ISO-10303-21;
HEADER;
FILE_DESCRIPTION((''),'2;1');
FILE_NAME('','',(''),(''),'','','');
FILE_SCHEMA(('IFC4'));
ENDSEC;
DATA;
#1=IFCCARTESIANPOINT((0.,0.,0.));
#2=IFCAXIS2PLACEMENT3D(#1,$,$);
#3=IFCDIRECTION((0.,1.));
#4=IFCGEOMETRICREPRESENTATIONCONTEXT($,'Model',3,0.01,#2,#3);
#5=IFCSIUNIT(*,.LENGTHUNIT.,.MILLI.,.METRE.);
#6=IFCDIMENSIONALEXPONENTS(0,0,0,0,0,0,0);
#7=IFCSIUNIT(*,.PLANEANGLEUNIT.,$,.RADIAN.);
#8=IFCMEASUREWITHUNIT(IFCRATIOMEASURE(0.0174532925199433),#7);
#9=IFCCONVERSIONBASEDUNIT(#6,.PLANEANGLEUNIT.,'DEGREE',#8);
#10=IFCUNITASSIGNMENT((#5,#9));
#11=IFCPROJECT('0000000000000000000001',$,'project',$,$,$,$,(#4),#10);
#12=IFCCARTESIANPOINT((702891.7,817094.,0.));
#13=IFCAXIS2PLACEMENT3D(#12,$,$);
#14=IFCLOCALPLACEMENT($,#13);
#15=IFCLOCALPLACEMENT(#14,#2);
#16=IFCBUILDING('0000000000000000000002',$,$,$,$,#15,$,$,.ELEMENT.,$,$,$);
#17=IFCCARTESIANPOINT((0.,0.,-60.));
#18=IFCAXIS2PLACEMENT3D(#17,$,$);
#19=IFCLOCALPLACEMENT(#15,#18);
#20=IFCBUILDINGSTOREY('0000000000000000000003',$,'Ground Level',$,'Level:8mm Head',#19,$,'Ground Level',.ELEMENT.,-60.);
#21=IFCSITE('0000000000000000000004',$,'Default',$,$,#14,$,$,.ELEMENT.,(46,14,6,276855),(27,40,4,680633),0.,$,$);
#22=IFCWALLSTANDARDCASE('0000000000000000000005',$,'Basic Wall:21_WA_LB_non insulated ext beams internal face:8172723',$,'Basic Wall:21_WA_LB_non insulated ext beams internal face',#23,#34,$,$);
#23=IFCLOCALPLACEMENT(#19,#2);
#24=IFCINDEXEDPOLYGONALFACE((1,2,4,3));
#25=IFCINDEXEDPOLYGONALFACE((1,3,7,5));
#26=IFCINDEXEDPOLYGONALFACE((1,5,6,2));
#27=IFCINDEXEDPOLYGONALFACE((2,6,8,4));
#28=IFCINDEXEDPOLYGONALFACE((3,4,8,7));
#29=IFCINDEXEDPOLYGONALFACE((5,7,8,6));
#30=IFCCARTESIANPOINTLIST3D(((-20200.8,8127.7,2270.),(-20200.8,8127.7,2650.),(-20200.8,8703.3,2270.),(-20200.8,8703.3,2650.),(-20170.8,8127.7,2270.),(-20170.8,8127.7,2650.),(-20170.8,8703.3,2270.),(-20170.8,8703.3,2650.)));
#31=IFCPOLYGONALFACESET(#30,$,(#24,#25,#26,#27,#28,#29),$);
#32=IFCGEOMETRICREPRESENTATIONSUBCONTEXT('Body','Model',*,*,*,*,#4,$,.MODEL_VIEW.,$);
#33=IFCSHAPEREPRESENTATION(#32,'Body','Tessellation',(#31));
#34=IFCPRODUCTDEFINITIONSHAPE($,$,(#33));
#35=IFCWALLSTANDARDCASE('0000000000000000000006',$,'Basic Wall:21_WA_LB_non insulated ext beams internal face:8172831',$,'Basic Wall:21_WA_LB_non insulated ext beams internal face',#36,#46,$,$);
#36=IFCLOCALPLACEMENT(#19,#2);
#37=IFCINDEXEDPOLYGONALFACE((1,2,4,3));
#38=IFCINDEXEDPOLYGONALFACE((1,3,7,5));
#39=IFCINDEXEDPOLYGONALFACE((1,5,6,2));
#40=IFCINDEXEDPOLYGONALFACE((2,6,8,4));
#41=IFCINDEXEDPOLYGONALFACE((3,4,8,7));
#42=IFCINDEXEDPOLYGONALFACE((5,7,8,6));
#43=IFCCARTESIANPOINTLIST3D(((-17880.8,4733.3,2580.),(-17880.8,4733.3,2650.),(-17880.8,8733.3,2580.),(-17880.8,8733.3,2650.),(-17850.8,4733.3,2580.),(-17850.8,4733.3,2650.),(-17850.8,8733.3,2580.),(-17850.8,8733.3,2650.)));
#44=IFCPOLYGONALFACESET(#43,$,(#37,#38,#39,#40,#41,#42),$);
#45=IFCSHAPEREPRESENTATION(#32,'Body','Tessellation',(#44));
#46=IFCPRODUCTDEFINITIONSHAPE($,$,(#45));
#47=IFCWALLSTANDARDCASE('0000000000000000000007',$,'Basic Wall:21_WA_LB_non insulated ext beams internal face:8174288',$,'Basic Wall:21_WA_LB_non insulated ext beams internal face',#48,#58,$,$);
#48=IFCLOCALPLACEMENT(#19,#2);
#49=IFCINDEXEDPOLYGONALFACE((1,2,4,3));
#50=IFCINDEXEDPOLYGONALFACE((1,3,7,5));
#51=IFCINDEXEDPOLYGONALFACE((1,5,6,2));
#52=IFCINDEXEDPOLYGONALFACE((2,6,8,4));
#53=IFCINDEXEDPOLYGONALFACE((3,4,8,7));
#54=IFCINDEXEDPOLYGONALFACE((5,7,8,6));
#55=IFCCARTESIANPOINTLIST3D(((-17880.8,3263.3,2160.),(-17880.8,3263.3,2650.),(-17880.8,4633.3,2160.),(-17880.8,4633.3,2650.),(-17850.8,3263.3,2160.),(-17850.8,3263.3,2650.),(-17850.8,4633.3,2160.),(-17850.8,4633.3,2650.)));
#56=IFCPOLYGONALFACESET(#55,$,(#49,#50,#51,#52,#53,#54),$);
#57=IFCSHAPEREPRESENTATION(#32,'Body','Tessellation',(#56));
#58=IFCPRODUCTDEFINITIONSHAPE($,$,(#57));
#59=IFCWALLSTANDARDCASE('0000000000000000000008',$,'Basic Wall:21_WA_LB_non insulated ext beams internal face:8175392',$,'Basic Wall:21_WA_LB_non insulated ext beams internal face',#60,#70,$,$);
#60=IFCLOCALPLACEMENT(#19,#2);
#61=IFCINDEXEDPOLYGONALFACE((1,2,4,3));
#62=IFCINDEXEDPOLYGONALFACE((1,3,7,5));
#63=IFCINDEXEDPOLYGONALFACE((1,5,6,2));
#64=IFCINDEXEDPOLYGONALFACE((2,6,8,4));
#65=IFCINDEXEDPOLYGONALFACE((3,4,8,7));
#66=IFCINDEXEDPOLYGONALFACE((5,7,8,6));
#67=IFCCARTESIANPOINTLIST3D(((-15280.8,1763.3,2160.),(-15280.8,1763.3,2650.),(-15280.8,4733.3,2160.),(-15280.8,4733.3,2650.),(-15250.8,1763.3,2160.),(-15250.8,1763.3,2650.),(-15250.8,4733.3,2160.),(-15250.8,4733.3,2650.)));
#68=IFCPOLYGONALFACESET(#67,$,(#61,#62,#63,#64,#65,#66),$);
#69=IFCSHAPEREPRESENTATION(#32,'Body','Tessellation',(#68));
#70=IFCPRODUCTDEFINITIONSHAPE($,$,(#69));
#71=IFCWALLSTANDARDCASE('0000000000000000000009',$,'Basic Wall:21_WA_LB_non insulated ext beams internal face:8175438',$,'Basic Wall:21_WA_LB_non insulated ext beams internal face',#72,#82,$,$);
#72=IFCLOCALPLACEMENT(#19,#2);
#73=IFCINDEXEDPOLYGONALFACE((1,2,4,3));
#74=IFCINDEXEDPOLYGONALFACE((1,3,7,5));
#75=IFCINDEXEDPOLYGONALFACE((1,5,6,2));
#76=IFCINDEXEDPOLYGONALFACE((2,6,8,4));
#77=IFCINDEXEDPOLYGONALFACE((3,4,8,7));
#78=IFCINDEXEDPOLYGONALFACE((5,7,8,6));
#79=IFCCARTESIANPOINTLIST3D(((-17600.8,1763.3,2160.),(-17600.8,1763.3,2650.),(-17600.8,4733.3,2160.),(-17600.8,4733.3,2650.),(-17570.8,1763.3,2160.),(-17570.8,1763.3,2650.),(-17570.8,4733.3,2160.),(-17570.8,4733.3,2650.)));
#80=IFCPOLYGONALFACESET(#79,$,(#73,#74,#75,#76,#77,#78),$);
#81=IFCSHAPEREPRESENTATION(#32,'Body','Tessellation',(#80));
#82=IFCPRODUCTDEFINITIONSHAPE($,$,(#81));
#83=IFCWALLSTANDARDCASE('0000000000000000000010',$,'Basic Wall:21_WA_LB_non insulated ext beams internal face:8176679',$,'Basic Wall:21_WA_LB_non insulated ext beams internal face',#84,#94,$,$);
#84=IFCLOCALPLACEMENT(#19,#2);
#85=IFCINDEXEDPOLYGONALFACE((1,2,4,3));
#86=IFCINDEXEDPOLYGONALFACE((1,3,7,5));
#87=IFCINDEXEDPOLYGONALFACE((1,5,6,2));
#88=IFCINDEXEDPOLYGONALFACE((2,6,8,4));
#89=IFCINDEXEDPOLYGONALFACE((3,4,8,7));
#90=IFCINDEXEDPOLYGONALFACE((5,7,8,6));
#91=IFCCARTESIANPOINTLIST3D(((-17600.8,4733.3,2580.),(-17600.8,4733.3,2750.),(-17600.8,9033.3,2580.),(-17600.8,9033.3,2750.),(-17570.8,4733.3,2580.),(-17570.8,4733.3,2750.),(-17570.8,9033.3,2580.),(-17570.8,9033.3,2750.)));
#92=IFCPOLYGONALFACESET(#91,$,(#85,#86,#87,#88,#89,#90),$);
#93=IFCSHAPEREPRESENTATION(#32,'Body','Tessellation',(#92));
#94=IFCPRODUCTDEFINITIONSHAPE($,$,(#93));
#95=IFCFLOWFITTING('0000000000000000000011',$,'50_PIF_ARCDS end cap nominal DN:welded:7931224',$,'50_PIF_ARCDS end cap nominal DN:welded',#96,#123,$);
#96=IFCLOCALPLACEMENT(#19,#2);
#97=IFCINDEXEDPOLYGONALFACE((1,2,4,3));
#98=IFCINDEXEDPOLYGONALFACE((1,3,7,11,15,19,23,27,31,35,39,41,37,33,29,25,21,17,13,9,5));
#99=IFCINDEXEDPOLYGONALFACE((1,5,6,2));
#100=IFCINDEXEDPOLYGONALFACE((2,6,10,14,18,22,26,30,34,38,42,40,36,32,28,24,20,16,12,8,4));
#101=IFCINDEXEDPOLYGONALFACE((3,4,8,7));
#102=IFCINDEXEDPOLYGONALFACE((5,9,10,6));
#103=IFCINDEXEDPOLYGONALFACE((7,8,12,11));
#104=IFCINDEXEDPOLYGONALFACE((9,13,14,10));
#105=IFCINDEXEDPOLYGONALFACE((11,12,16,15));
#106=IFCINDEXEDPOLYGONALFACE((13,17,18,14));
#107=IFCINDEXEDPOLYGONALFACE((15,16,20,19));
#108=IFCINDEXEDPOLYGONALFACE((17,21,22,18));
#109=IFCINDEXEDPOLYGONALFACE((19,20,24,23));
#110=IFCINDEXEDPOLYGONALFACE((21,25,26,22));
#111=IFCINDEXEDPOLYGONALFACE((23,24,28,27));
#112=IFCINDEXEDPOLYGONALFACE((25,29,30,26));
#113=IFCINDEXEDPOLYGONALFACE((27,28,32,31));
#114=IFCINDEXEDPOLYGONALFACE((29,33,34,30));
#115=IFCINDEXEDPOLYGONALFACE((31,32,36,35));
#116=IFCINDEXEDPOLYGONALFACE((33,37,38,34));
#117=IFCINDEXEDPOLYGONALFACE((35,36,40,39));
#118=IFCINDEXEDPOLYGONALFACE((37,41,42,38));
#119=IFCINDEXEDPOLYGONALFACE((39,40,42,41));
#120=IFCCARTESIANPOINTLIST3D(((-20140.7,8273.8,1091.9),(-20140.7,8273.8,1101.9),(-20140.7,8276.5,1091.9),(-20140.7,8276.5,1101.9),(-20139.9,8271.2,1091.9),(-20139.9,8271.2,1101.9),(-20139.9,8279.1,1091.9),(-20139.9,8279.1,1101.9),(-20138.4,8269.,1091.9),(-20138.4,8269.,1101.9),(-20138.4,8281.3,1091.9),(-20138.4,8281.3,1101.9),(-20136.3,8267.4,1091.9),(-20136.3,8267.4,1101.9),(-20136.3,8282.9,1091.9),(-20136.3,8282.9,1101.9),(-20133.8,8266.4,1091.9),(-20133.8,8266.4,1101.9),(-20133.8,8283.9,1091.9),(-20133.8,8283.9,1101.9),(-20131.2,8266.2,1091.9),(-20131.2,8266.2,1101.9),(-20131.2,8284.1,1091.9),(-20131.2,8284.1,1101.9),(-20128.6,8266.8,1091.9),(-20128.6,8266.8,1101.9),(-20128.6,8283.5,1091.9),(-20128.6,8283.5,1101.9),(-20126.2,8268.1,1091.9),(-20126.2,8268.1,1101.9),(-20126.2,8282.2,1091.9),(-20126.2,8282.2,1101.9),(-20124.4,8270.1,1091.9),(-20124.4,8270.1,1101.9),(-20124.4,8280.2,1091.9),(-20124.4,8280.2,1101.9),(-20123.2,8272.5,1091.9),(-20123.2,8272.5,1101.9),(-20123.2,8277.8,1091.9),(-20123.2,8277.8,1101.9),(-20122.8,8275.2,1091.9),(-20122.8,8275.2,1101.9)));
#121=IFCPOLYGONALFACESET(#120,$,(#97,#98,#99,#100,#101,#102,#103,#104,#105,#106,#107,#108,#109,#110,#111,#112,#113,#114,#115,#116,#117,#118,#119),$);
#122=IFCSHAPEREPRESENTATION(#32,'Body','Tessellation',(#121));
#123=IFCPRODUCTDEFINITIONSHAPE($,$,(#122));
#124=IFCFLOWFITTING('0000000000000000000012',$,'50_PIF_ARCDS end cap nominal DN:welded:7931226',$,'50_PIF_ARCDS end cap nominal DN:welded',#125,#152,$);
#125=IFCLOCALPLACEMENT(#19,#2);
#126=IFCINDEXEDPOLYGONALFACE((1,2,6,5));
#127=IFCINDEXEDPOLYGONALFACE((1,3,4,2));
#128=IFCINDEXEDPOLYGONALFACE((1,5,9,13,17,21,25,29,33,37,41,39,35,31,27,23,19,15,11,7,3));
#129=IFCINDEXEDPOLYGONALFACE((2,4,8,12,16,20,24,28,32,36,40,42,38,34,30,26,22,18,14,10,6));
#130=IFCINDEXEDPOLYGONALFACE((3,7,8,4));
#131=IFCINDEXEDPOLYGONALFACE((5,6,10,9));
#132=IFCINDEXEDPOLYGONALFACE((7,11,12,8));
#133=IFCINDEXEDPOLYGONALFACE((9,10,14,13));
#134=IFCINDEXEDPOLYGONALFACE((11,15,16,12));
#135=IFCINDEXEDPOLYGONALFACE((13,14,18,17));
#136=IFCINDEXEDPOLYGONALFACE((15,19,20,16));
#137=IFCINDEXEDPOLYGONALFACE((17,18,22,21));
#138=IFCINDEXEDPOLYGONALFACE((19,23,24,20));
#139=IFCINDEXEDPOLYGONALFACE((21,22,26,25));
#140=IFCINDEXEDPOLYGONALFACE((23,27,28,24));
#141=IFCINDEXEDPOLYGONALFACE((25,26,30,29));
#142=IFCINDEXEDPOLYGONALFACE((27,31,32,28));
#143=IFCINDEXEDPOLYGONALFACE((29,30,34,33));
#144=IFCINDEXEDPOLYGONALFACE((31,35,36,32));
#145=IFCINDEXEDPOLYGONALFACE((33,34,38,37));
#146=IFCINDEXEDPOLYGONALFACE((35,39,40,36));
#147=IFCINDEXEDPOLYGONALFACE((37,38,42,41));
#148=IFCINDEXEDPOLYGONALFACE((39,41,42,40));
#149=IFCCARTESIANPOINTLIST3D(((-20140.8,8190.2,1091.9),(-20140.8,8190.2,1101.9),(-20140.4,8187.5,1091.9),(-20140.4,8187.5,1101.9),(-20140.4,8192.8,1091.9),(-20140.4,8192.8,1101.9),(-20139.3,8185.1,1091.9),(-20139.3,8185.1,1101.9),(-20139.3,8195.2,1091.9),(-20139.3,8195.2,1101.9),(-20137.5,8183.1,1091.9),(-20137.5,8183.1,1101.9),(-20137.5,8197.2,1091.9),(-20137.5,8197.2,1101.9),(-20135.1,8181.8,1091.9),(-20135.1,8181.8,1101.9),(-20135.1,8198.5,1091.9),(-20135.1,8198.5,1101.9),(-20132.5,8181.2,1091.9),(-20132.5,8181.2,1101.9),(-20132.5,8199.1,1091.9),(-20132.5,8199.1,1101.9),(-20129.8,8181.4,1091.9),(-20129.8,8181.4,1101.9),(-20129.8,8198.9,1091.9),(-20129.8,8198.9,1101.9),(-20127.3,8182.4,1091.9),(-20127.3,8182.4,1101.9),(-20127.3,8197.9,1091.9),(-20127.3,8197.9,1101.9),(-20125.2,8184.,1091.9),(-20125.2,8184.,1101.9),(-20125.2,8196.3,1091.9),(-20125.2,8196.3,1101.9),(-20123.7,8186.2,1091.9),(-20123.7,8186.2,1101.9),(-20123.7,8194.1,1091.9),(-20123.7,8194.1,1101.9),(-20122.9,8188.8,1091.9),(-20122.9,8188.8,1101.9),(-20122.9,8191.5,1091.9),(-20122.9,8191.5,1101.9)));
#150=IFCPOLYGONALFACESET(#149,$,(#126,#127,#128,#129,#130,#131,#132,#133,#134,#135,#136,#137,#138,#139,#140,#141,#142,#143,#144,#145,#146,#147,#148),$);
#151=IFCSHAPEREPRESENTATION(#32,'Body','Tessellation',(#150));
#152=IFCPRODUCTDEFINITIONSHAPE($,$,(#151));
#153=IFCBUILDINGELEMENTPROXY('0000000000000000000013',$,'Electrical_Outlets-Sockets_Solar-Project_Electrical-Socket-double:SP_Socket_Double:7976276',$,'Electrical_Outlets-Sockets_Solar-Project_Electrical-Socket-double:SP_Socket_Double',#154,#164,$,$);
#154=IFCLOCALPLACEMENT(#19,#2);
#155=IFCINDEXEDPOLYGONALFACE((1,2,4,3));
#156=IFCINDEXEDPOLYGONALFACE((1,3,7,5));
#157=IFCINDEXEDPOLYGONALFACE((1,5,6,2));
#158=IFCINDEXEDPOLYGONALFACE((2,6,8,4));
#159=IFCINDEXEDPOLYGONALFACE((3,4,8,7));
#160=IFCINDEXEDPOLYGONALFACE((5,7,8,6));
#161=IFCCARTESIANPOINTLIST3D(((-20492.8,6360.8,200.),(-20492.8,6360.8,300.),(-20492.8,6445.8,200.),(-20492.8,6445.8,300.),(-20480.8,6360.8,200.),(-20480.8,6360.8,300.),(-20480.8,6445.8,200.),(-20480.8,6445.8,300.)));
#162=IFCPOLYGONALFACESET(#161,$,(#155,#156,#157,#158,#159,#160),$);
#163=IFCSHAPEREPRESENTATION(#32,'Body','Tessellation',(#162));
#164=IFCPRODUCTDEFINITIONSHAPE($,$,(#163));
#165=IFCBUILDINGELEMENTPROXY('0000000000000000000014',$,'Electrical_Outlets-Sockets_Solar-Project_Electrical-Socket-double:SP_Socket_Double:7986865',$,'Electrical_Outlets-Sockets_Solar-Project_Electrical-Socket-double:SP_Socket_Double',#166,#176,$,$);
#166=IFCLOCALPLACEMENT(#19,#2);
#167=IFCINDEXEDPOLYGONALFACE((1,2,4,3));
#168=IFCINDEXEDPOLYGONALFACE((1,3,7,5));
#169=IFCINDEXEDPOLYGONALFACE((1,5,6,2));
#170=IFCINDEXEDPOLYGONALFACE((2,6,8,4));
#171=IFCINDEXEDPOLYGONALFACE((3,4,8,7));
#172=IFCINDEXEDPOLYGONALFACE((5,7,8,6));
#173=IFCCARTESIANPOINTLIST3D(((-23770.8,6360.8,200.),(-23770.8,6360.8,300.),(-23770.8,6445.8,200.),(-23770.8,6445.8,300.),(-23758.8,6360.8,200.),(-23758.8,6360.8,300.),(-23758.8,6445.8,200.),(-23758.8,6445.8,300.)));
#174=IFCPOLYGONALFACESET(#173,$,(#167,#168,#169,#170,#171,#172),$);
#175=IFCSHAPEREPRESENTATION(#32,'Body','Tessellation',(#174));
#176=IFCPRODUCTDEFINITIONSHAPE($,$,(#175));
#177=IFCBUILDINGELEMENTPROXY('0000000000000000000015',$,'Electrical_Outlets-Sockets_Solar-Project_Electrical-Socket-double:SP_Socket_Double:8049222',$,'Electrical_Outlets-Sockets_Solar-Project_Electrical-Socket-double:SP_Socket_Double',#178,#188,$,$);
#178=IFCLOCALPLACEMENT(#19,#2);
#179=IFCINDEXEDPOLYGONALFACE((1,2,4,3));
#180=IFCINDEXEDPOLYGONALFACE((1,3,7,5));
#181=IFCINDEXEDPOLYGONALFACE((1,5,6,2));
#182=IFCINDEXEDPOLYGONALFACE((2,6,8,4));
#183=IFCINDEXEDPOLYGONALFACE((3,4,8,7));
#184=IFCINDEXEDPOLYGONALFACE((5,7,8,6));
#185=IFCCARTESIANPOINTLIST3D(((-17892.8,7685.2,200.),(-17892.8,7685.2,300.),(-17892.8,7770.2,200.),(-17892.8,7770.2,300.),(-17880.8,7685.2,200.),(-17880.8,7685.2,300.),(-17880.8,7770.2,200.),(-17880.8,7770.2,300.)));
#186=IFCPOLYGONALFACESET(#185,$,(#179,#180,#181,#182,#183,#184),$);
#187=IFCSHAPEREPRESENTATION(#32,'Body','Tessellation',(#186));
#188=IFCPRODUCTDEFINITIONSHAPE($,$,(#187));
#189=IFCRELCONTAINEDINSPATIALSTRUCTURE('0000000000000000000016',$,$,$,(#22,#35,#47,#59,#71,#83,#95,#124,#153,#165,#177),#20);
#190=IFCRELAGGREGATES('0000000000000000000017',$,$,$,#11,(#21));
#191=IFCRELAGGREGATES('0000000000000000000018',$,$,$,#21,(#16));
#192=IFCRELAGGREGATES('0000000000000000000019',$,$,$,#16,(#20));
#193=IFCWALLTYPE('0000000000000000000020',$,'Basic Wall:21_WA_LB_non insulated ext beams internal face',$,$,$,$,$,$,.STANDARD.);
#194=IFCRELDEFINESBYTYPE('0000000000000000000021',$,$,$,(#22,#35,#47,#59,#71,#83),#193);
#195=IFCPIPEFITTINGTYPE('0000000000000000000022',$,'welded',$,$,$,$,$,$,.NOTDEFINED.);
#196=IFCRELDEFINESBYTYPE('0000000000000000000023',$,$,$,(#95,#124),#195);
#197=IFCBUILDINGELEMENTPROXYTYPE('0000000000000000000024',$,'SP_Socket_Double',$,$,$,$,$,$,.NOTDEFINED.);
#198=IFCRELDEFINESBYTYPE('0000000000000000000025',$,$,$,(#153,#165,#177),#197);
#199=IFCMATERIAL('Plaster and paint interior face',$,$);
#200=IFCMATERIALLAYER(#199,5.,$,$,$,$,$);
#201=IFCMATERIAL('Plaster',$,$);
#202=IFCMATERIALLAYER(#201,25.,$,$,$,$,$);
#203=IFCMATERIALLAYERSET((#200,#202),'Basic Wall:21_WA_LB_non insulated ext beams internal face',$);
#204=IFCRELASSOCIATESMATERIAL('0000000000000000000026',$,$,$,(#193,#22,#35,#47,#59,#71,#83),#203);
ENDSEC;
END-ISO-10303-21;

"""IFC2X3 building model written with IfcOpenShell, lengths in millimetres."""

from ifc_helpers import new_model, entity, si_unit, converted_unit, direction, frame, frame_2d, origin, origin_2d_with_axis, place, context, subcontext, project, spatial, rectangle, circle, extrude, source, transform, mapped, material, layer, layer_set, layer_usage, type_object, type_shapes, element, save


model = new_model("IFC2X3")

# Units and contexts
model_context = context("Model", 3, precision=0.01, world=origin(), true_north=direction((0.0, 1.0)))
body_context = subcontext(model_context, "Body", "Model", "MODEL_VIEW")
ifc_project = project(units=[si_unit("LENGTHUNIT", "METRE", prefix="MILLI"), converted_unit("PLANEANGLEUNIT", "DEGREE", entity("IfcRatioMeasure", 0.0174532925199433), si_unit("PLANEANGLEUNIT", "RADIAN"), dimensions=[0, 0, 0, 0, 0, 0, 0])], contexts=[model_context])

# Site, building, storey
site_placement = place(None, frame((702891.7, 817094.0, 0.0)))
site = spatial("IfcSite", under=ifc_project, at=site_placement, Name="Default", CompositionType="ELEMENT", RefLatitude=(46, 14, 6, 276855), RefLongitude=(27, 40, 4, 680633), RefElevation=0.0)
building_placement = place(site_placement, origin())
building = spatial("IfcBuilding", under=site, at=building_placement, CompositionType="ELEMENT")
storey_placement = place(building_placement, frame((0.0, 0.0, -60.0)))
storey = spatial("IfcBuildingStorey", under=building, at=storey_placement, Name="Ground Level", ObjectType="Level:8mm Head", LongName="Ground Level", CompositionType="ELEMENT", Elevation=-60.0)

# Walls
ifc_material_1 = material(Name="Plaster")
ifc_material_2 = material(Name="Plaster and paint interior face")
ifc_layer_1 = layer(ifc_material_2, 5.0)
ifc_layer_2 = layer(ifc_material_1, 25.0)
ifc_layer_set_1 = layer_set([ifc_layer_1, ifc_layer_2], Name="Basic Wall:21_WA_LB_non insulated ext beams internal face")
wall_type_1 = type_object("IfcWallType", Name="Basic Wall:21_WA_LB_non insulated ext beams internal face", PredefinedType="STANDARD", material=ifc_layer_set_1)
ifc_layer_usage_1 = layer_usage(ifc_layer_set_1, "AXIS2", "POSITIVE", -15.0)
wall_1_placement = place(storey_placement, frame((-20185.8, 8127.7, 2270.0), z_axis=(0.0, 0.0, 1.0), x_axis=(0.0, 1.0, 0.0)))
element("IfcWallStandardCase", 1, at=wall_1_placement, inside=storey, type_object=wall_type_1, material=ifc_layer_usage_1, Name="Basic Wall:21_WA_LB_non insulated ext beams internal face:8172723", ObjectType="Basic Wall:21_WA_LB_non insulated ext beams internal face", context=body_context, shape_type="SweptSolid", body=[
    extrude(rectangle(XDim=575.6, YDim=30.0, at=frame_2d((287.8, 0.0), x_axis=(-1.0, 0.0))), origin(), (0.0, 0.0, 1.0), 380.0),
])
ifc_layer_usage_2 = layer_usage(ifc_layer_set_1, "AXIS2", "NEGATIVE", 15.0)
wall_2_placement = place(storey_placement, frame((-17865.8, 4733.3, 2580.0), z_axis=(0.0, 0.0, 1.0), x_axis=(0.0, 1.0, 0.0)))
element("IfcWallStandardCase", 2, at=wall_2_placement, inside=storey, type_object=wall_type_1, material=ifc_layer_usage_2, Name="Basic Wall:21_WA_LB_non insulated ext beams internal face:8172831", ObjectType="Basic Wall:21_WA_LB_non insulated ext beams internal face", context=body_context, shape_type="SweptSolid", body=[
    extrude(rectangle(XDim=4000.0, YDim=30.0, at=frame_2d((2000.0, 0.0), x_axis=(-1.0, 0.0))), origin(), (0.0, 0.0, 1.0), 70.0),
])
ifc_layer_usage_3 = layer_usage(ifc_layer_set_1, "AXIS2", "POSITIVE", -15.0)
wall_3_placement = place(storey_placement, frame((-17865.8, 4633.3, 2160.0), z_axis=(0.0, 0.0, 1.0), x_axis=(0.0, -1.0, 0.0)))
element("IfcWallStandardCase", 3, at=wall_3_placement, inside=storey, type_object=wall_type_1, material=ifc_layer_usage_3, Name="Basic Wall:21_WA_LB_non insulated ext beams internal face:8174288", ObjectType="Basic Wall:21_WA_LB_non insulated ext beams internal face", context=body_context, shape_type="SweptSolid", body=[
    extrude(rectangle(XDim=1370.0, YDim=30.0, at=frame_2d((685.0, 0.0), x_axis=(-1.0, 0.0))), origin(), (0.0, 0.0, 1.0), 490.0),
])
ifc_layer_usage_4 = layer_usage(ifc_layer_set_1, "AXIS2", "POSITIVE", -15.0)
wall_4_placement = place(storey_placement, frame((-15265.8, 4733.3, 2160.0), z_axis=(0.0, 0.0, 1.0), x_axis=(0.0, -1.0, 0.0)))
element("IfcWallStandardCase", 4, at=wall_4_placement, inside=storey, type_object=wall_type_1, material=ifc_layer_usage_4, Name="Basic Wall:21_WA_LB_non insulated ext beams internal face:8175392", ObjectType="Basic Wall:21_WA_LB_non insulated ext beams internal face", context=body_context, shape_type="SweptSolid", body=[
    extrude(rectangle(XDim=2970.0, YDim=30.0, at=frame_2d((1485.0, 0.0), x_axis=(-1.0, 0.0))), origin(), (0.0, 0.0, 1.0), 490.0),
])
ifc_layer_usage_5 = layer_usage(ifc_layer_set_1, "AXIS2", "NEGATIVE", 15.0)
wall_5_placement = place(storey_placement, frame((-17585.8, 4733.3, 2160.0), z_axis=(0.0, 0.0, 1.0), x_axis=(0.0, -1.0, 0.0)))
element("IfcWallStandardCase", 5, at=wall_5_placement, inside=storey, type_object=wall_type_1, material=ifc_layer_usage_5, Name="Basic Wall:21_WA_LB_non insulated ext beams internal face:8175438", ObjectType="Basic Wall:21_WA_LB_non insulated ext beams internal face", context=body_context, shape_type="SweptSolid", body=[
    extrude(rectangle(XDim=2970.0, YDim=30.0, at=frame_2d((1485.0, 0.0), x_axis=(-1.0, 0.0))), origin(), (0.0, 0.0, 1.0), 490.0),
])
ifc_layer_usage_6 = layer_usage(ifc_layer_set_1, "AXIS2", "NEGATIVE", 15.0)
wall_6_placement = place(storey_placement, frame((-17585.8, 9033.3, 2580.0), z_axis=(0.0, 0.0, 1.0), x_axis=(0.0, -1.0, 0.0)))
element("IfcWallStandardCase", 6, at=wall_6_placement, inside=storey, type_object=wall_type_1, material=ifc_layer_usage_6, Name="Basic Wall:21_WA_LB_non insulated ext beams internal face:8176679", ObjectType="Basic Wall:21_WA_LB_non insulated ext beams internal face", context=body_context, shape_type="SweptSolid", body=[
    extrude(rectangle(XDim=4300.0, YDim=30.0, at=frame_2d((2150.0, 0.0), x_axis=(-1.0, 0.0))), origin(), (0.0, 0.0, 1.0), 170.0),
])

# Flow fittings
pipe_fitting_type = type_object("IfcPipeFittingType", Name="welded", PredefinedType="NOTDEFINED")
shared_shape_1 = source(origin(), body_context, "Body", "SweptSolid", [
    extrude(circle(Radius=9.0, at=frame_2d((0.0, 0.0), x_axis=(1.0, 0.0))), frame((0.0, 0.0, 0.0), z_axis=(1.0, 0.0, 0.0), x_axis=(0.0, 1.0, 0.0)), (0.0, 0.0, 1.0), 10.0),
])
type_shapes(pipe_fitting_type, [shared_shape_1])
for number, where, z_axis, x_axis, name in (
    (7, (-20131.8, 8275.2, 1091.9), (0.0, 1.0, 0.0), (0.0, 0.0, 1.0), "50_PIF_ARCDS end cap nominal DN:welded:7931224"),
    (8, (-20131.8, 8190.2, 1091.9), (0.0, -1.0, 0.0), (0.0, 0.0, 1.0), "50_PIF_ARCDS end cap nominal DN:welded:7931226"),
):
    element("IfcFlowFitting", number, at=place(storey_placement, frame(where, z_axis=z_axis, x_axis=x_axis)), inside=storey, type_object=pipe_fitting_type, Name=name, ObjectType="50_PIF_ARCDS end cap nominal DN:welded", context=body_context, shape_type="MappedRepresentation", body=[
        mapped(shared_shape_1, transform((0.0, 0.0, 0.0), scale=1.0)),
    ])

# Building element proxies
building_element_proxy_type_1 = type_object("IfcBuildingElementProxyType", Name="SP_Socket_Double", PredefinedType="NOTDEFINED")
shared_shape_2 = source(origin(), body_context, "Body", "SweptSolid", [
    extrude(rectangle(XDim=85.0, YDim=12.0, at=origin_2d_with_axis()), frame((0.0, 6.0, -100.0), z_axis=(0.0, 0.0, 1.0), x_axis=(-1.0, 0.0, 0.0)), (0.0, 0.0, 1.0), 100.0),
])
type_shapes(building_element_proxy_type_1, [shared_shape_2])
for number, where, z_axis, x_axis, name in (
    (9, (-20480.8, 6403.3, 300.0), (0.0, 0.0, 1.0), (0.0, 1.0, 0.0), "Electrical_Outlets-Sockets_Solar-Project_Electrical-Socket-double:SP_Socket_Double:7976276"),
    (10, (-23770.8, 6403.3, 300.0), (0.0, 0.0, 1.0), (0.0, -1.0, 0.0), "Electrical_Outlets-Sockets_Solar-Project_Electrical-Socket-double:SP_Socket_Double:7986865"),
    (11, (-17880.8, 7727.7, 300.0), (0.0, 0.0, 1.0), (0.0, 1.0, 0.0), "Electrical_Outlets-Sockets_Solar-Project_Electrical-Socket-double:SP_Socket_Double:8049222"),
):
    element("IfcBuildingElementProxy", number, at=place(storey_placement, frame(where, z_axis=z_axis, x_axis=x_axis)), inside=storey, type_object=building_element_proxy_type_1, Name=name, ObjectType="Electrical_Outlets-Sockets_Solar-Project_Electrical-Socket-double:SP_Socket_Double", context=body_context, shape_type="MappedRepresentation", body=[
        mapped(shared_shape_2, transform((0.0, 0.0, 0.0), scale=1.0)),
    ])

save(model, "model.ifc")
